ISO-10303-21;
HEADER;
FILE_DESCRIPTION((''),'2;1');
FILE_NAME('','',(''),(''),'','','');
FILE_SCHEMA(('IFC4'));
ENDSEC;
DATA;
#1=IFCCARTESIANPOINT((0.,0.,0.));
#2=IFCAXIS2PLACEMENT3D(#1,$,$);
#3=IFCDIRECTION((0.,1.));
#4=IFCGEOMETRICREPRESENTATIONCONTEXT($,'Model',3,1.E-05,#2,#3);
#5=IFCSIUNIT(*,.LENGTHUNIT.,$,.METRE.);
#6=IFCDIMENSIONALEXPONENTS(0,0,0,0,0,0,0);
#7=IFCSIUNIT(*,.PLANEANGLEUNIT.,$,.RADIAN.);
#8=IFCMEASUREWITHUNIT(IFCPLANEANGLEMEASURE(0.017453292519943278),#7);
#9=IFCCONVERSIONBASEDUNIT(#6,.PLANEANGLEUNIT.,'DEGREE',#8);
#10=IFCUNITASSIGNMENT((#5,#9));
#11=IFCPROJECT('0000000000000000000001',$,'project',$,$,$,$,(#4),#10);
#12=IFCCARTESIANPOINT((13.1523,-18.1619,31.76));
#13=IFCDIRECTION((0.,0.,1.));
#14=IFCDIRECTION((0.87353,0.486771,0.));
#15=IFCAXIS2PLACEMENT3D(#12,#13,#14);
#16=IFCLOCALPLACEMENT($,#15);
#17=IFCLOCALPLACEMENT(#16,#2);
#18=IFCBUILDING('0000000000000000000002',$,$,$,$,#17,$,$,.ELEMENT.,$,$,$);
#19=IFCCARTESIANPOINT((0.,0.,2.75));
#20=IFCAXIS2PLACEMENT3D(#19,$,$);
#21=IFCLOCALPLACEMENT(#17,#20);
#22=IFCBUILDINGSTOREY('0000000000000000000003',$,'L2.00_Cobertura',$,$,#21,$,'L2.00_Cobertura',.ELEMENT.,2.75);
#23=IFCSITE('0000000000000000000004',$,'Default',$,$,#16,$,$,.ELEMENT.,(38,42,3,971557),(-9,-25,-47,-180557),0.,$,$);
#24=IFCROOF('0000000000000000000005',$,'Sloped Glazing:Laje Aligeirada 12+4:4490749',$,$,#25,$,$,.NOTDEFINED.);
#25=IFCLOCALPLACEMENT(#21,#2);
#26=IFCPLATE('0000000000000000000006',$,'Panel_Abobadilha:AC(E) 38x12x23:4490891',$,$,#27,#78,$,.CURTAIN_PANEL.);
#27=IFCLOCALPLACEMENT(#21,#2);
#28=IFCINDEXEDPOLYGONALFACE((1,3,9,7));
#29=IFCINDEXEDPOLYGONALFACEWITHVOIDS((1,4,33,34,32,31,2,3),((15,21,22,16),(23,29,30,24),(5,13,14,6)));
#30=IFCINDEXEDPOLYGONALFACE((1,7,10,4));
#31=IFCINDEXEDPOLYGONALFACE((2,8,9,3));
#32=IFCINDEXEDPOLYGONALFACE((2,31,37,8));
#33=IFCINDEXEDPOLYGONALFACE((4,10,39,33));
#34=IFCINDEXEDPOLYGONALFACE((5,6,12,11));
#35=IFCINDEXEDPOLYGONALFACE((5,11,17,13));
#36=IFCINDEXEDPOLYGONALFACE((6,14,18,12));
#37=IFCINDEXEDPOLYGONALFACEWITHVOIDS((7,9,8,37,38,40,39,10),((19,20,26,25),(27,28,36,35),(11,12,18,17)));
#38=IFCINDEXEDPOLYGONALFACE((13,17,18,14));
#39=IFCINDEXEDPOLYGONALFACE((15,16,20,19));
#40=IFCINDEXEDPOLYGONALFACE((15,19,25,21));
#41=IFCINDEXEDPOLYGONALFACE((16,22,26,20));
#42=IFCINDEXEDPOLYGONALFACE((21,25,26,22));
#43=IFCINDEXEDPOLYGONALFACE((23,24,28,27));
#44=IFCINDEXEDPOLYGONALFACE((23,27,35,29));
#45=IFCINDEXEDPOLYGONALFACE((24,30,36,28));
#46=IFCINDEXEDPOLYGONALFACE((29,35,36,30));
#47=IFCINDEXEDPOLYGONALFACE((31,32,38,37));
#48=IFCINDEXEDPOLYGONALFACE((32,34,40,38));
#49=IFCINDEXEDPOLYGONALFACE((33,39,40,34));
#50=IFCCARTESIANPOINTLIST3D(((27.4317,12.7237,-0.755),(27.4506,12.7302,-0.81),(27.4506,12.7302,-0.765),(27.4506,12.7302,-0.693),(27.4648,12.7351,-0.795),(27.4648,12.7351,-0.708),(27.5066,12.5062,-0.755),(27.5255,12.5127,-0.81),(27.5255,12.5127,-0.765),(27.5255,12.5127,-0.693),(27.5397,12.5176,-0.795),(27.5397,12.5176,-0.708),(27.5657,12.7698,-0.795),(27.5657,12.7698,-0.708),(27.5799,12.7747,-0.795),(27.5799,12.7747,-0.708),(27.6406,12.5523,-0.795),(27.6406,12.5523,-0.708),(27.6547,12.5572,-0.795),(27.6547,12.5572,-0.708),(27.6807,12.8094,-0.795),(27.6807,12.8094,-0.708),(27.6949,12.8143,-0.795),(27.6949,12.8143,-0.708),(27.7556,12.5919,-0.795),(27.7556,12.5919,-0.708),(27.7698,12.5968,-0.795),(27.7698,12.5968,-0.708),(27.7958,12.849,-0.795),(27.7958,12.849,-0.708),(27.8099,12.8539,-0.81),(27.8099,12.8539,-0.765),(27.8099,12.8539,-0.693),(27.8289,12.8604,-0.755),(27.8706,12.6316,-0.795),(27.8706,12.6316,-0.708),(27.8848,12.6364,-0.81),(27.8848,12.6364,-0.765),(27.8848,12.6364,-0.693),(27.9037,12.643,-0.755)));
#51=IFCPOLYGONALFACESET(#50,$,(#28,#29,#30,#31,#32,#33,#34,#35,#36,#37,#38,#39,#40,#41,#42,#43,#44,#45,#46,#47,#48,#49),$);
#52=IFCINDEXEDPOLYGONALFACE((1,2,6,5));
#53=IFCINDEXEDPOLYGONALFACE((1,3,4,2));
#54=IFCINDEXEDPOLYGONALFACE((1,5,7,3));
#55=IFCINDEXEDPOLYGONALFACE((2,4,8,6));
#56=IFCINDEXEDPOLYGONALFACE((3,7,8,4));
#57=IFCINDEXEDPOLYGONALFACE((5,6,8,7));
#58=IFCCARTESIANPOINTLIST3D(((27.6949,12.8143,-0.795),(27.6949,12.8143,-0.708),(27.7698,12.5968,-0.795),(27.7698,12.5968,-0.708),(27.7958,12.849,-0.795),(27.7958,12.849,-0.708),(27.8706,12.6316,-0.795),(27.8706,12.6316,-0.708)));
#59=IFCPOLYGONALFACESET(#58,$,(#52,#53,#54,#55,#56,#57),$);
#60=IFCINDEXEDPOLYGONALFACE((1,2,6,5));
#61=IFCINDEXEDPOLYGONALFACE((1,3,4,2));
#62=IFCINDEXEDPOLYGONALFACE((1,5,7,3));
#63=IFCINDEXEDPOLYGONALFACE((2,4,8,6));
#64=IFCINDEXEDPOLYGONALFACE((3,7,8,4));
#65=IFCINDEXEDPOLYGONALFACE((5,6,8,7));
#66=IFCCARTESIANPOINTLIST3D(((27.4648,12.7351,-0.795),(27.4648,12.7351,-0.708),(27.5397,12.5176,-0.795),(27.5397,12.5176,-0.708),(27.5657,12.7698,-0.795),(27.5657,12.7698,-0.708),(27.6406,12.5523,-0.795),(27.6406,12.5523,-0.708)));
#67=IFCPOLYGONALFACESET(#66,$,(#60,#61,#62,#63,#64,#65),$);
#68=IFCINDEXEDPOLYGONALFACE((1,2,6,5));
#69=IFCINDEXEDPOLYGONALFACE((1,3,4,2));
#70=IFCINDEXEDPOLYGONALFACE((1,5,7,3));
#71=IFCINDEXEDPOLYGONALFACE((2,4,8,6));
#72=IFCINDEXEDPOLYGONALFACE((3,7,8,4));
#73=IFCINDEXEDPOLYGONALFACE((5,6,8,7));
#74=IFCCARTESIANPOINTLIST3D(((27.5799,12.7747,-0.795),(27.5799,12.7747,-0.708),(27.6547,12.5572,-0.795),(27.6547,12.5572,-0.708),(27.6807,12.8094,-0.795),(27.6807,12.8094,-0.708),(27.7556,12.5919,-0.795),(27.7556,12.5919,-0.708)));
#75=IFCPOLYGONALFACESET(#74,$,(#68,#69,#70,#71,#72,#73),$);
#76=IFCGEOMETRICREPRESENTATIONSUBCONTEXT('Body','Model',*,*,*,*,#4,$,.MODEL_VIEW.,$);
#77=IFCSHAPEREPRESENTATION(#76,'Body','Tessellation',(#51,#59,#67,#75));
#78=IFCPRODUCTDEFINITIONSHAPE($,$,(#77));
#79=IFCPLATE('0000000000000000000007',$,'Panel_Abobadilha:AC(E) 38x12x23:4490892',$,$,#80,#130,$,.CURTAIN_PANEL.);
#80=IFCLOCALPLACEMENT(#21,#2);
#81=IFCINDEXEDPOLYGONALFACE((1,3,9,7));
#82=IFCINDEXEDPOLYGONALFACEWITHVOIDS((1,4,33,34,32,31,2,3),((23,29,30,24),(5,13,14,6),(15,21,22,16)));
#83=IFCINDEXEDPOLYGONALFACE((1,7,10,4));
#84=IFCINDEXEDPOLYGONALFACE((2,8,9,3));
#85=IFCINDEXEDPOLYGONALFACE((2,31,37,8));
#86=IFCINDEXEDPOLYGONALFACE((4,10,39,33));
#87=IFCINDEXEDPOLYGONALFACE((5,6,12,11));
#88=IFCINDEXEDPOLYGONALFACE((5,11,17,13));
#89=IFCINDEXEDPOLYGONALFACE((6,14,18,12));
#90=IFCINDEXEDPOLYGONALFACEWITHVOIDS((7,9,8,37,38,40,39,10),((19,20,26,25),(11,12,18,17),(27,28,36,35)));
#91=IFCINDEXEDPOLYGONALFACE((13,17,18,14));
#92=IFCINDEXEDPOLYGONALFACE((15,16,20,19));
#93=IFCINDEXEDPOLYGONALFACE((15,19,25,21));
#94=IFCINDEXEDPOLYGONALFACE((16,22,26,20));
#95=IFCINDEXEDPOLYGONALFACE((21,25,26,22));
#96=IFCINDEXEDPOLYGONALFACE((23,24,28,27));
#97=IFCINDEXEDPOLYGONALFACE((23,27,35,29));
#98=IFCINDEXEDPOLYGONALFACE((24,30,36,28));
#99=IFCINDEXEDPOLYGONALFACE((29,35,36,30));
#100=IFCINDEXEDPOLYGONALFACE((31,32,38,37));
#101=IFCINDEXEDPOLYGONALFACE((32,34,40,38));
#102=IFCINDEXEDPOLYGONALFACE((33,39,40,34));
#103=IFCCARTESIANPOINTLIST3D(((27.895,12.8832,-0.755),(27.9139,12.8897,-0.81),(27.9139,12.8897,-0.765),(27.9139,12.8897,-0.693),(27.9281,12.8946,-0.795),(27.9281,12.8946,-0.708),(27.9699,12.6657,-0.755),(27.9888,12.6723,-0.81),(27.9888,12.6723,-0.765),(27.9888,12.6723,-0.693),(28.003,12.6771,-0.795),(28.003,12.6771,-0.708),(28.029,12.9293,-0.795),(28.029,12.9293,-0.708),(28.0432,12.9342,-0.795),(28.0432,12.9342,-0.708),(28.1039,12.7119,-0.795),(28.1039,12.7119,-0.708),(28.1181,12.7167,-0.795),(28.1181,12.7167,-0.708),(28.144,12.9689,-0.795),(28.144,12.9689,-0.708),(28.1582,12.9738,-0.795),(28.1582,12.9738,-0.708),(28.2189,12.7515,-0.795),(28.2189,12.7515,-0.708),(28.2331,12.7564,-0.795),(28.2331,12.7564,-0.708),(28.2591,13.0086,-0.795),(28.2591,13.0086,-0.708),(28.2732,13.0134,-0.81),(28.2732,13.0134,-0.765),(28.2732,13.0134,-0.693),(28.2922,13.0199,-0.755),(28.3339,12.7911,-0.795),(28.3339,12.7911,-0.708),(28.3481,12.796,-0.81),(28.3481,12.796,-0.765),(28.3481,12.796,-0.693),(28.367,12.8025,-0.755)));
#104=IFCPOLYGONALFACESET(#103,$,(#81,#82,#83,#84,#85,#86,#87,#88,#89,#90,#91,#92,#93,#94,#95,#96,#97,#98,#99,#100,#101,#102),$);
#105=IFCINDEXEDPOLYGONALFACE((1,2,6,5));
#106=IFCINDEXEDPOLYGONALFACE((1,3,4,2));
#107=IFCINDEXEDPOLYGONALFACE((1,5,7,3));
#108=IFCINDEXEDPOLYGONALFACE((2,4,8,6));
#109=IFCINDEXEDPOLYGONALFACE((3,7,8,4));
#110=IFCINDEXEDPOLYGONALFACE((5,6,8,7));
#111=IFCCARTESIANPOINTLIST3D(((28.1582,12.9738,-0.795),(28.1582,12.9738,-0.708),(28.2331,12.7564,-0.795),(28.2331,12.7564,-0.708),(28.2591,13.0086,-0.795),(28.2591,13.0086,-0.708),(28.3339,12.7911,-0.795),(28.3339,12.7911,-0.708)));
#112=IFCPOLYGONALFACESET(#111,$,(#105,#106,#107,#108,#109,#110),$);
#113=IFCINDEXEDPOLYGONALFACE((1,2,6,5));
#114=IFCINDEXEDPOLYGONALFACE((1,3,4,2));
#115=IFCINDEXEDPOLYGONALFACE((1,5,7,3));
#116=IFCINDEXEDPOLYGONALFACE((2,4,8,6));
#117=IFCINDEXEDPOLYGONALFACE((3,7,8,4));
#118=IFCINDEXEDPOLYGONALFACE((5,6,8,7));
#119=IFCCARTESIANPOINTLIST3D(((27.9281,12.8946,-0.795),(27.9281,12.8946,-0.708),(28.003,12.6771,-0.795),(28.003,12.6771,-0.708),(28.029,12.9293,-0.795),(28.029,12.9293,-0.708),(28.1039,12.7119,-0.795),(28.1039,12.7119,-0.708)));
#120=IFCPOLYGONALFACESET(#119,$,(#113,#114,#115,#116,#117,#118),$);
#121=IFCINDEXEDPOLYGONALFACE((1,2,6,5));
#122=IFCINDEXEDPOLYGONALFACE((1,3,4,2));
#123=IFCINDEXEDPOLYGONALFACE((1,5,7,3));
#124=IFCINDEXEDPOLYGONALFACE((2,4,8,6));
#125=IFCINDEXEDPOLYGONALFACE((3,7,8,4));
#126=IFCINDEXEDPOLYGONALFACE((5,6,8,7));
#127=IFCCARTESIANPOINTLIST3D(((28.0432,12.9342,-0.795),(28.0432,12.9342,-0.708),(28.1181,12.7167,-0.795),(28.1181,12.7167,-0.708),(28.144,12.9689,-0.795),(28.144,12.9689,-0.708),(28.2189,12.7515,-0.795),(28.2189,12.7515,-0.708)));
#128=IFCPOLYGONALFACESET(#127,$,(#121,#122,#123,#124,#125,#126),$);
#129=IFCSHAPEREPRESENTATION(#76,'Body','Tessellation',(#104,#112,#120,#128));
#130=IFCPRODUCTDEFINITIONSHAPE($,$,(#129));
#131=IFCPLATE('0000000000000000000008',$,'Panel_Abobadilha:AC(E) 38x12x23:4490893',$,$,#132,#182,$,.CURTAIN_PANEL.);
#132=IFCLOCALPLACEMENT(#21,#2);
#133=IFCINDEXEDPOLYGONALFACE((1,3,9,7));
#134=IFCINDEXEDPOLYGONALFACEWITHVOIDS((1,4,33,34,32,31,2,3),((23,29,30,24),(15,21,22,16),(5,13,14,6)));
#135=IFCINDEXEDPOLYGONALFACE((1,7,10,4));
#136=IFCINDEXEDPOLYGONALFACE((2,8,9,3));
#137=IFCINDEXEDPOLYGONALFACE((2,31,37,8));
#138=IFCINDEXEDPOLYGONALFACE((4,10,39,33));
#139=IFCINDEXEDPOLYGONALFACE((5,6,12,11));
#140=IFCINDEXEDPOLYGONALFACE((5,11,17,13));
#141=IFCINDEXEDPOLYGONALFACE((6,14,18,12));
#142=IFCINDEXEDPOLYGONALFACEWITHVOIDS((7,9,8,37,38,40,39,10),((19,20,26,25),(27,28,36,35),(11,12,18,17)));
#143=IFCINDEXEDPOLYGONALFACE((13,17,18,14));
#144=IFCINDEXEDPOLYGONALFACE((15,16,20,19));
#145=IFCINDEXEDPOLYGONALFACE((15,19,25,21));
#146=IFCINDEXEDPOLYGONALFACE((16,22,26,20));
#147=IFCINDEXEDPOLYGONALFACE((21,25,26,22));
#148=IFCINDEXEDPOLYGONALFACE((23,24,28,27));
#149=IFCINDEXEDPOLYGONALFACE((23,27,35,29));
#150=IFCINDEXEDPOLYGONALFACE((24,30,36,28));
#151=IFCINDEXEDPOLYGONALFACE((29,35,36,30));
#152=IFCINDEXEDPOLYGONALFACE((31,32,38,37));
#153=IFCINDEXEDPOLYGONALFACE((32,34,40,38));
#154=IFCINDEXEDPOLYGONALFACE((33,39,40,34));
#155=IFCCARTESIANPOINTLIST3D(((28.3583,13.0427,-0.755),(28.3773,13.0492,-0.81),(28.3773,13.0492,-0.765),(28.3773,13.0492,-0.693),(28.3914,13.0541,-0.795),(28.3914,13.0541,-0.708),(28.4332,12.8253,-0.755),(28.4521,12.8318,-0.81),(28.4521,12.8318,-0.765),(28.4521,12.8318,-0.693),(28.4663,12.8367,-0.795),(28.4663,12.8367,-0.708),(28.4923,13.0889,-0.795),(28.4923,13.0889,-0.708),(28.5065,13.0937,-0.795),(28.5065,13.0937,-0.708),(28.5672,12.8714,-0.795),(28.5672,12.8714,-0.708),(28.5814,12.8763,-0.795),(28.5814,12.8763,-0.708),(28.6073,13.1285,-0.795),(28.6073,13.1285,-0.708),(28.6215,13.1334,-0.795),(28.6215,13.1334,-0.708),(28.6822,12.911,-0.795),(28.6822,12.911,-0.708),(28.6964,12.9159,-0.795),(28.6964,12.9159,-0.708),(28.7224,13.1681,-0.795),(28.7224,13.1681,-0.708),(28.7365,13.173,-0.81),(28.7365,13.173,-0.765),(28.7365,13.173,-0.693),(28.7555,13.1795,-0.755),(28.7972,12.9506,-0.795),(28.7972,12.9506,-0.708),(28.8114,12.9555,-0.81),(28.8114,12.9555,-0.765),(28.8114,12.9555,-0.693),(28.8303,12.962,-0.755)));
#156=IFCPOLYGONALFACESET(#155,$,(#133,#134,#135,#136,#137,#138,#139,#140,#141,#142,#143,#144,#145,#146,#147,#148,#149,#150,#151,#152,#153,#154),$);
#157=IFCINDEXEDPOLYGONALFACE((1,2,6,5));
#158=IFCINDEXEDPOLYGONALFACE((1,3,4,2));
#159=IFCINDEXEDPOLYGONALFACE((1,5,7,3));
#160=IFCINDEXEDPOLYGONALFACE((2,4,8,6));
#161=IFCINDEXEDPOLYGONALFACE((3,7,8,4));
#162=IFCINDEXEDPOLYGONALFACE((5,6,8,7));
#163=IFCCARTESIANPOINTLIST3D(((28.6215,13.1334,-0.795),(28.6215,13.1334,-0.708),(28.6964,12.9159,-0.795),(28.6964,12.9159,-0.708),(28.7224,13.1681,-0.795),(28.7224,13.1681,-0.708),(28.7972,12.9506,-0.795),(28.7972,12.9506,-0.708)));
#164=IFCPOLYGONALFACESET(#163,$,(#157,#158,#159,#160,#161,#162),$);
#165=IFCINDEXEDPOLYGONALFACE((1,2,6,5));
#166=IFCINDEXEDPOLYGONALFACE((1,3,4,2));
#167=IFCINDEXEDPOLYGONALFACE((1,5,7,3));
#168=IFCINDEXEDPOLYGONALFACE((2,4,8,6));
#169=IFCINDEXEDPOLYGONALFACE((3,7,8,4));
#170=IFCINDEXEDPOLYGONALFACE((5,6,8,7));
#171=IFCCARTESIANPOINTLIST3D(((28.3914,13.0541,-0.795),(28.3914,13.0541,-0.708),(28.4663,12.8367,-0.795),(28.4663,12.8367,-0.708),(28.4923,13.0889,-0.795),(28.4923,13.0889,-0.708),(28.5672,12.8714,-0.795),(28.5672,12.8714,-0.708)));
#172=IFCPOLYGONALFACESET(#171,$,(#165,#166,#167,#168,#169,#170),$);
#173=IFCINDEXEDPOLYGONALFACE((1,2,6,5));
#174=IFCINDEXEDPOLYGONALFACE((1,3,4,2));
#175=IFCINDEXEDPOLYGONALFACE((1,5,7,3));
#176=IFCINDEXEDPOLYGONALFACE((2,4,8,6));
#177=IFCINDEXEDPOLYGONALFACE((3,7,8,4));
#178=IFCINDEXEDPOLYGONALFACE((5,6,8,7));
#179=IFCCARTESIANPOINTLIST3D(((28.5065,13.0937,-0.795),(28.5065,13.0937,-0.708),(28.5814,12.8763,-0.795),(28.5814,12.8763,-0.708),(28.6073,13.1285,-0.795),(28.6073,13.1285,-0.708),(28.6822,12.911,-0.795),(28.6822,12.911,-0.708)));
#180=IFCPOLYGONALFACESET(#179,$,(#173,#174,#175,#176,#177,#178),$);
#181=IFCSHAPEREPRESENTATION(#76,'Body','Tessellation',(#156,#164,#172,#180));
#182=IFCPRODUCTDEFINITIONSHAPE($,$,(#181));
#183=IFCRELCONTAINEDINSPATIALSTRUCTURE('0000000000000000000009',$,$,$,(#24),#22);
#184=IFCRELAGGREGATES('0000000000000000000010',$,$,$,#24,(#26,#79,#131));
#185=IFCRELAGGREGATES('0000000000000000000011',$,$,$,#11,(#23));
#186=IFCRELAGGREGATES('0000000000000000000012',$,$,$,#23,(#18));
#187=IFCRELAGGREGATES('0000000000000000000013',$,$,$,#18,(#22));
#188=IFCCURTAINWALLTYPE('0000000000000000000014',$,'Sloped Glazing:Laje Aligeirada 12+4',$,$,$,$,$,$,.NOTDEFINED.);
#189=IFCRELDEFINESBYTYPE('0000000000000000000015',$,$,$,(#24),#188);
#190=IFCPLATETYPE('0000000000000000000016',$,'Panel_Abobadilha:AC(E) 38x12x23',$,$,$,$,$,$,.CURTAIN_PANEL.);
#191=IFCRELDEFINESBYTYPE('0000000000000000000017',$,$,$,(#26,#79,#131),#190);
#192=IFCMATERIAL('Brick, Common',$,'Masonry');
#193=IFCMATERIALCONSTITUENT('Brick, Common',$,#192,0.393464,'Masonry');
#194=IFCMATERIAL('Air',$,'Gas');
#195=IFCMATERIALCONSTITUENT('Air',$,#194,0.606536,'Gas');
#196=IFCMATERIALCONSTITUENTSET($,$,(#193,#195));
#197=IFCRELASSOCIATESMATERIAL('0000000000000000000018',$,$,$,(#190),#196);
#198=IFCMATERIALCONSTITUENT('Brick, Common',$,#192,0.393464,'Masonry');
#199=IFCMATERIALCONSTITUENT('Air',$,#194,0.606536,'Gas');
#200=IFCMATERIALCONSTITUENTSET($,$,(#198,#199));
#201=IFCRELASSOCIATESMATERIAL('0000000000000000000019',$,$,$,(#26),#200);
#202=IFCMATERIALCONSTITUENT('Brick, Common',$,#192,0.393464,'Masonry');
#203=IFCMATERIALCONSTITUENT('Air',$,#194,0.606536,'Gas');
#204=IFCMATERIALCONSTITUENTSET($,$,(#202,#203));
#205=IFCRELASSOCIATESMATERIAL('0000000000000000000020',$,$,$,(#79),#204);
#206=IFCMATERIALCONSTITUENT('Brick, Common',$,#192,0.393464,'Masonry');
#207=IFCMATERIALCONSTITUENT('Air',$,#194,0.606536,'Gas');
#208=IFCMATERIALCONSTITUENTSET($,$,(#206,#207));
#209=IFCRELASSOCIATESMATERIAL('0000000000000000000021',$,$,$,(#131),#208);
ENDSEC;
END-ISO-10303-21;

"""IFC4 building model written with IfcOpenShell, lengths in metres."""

from ifc_helpers import new_model, entity, si_unit, converted_unit, direction, frame, origin, place, context, subcontext, project, spatial, indexed_curve, outline, extrude, source, transform, mapped, material, constituent, constituent_set, type_object, type_shapes, element, aggregate, save


model = new_model("IFC4")

# Units and contexts
model_context = context("Model", 3, precision=1e-05, world=origin(), true_north=direction((0.0, 1.0)))
body_context = subcontext(model_context, "Body", "Model", "MODEL_VIEW")
ifc_project = project(units=[si_unit("LENGTHUNIT", "METRE"), converted_unit("PLANEANGLEUNIT", "DEGREE", entity("IfcPlaneAngleMeasure", 0.017453292519943278), si_unit("PLANEANGLEUNIT", "RADIAN"), dimensions=[0, 0, 0, 0, 0, 0, 0])], contexts=[model_context])

# Site, building, storey
site_placement = place(None, frame((13.1523, -18.1619, 31.76), z_axis=(0.0, 0.0, 1.0), x_axis=(0.87353, 0.486771, 0.0)))
site = spatial("IfcSite", under=ifc_project, at=site_placement, Name="Default", CompositionType="ELEMENT", RefLatitude=(38, 42, 3, 971557), RefLongitude=(-9, -25, -47, -180557), RefElevation=0.0)
building_placement = place(site_placement, origin())
building = spatial("IfcBuilding", under=site, at=building_placement, CompositionType="ELEMENT")
storey_placement = place(building_placement, frame((0.0, 0.0, 2.75)))
storey = spatial("IfcBuildingStorey", under=building, at=storey_placement, Name="L2.00_Cobertura", LongName="L2.00_Cobertura", CompositionType="ELEMENT", Elevation=2.75)

# Roof, plates
curtain_wall_type = type_object("IfcCurtainWallType", Name="Sloped Glazing:Laje Aligeirada 12+4", PredefinedType="NOTDEFINED")
roof_placement = place(storey_placement, frame((0.0, 0.0, -2.75)))
roof = element("IfcRoof", 1, at=roof_placement, inside=storey, type_object=curtain_wall_type, Name="Sloped Glazing:Laje Aligeirada 12+4:4490749", PredefinedType="NOTDEFINED")
ifc_material_1 = material(Name="Brick, Common", Category="Masonry")
ifc_material_2 = material(Name="Air", Category="Gas")
ifc_constituent_1 = constituent(ifc_material_1, Name="Brick, Common", Category="Masonry", fraction=0.393464)
ifc_constituent_2 = constituent(ifc_material_2, Name="Air", Category="Gas", fraction=0.606536)
ifc_constituent_set_1 = constituent_set(constituents=[ifc_constituent_1, ifc_constituent_2])
plate_type_1 = type_object("IfcPlateType", Name="Panel_Abobadilha:AC(E) 38x12x23", PredefinedType="CURTAIN_PANEL", material=ifc_constituent_set_1)
shared_shape_1 = source(origin(), body_context, "Body", "SweptSolid", [
    extrude(outline(indexed_curve([(-0.19, -0.0543), (0.19, -0.0543), (0.19, -0.0093), (0.21, 0.0007), (0.19, 0.0628), (-0.19, 0.0628), (-0.21, 0.0007), (-0.19, -0.0093), (-0.19, -0.0543)], self_intersect=False), holes=[indexed_curve([(-0.0683, 0.0477), (-0.0683, -0.0393), (-0.175, -0.0393), (-0.175, 0.0477), (-0.0683, 0.0477)], self_intersect=False), indexed_curve([(0.0533, 0.0477), (0.0533, -0.0393), (-0.0533, -0.0393), (-0.0533, 0.0477), (0.0533, 0.0477)], self_intersect=False), indexed_curve([(0.175, 0.0477), (0.175, -0.0393), (0.0683, -0.0393), (0.0683, 0.0477), (0.175, 0.0477)], self_intersect=False)]), frame((0.0, 0.0543, 0.0)), (0.0, 0.0, 1.0), 0.23),
    extrude(outline(indexed_curve([(-0.0533, -0.0435), (0.0533, -0.0435), (0.0533, 0.0435), (-0.0533, 0.0435), (-0.0533, -0.0435)], self_intersect=False)), frame((0.1217, 0.0585, 0.0), z_axis=(0.0, 0.0, 1.0), x_axis=(-1.0, 0.0, 0.0)), (0.0, 0.0, 1.0), 0.23),
    extrude(outline(indexed_curve([(-0.0533, -0.0435), (0.0533, -0.0435), (0.0533, 0.0435), (-0.0533, 0.0435), (-0.0533, -0.0435)], self_intersect=False)), frame((-0.1217, 0.0585, 0.0), z_axis=(0.0, 0.0, 1.0), x_axis=(-1.0, 0.0, 0.0)), (0.0, 0.0, 1.0), 0.23),
    extrude(outline(indexed_curve([(-0.0533, -0.0435), (0.0533, -0.0435), (0.0533, 0.0435), (-0.0533, 0.0435), (-0.0533, -0.0435)], self_intersect=False)), frame((0.0, 0.0585, 0.0), z_axis=(0.0, 0.0, 1.0), x_axis=(-1.0, 0.0, 0.0)), (0.0, 0.0, 1.0), 0.23),
])
type_shapes(plate_type_1, [shared_shape_1])
ifc_constituent_3 = constituent(ifc_material_1, Name="Brick, Common", Category="Masonry", fraction=0.393464)
ifc_constituent_4 = constituent(ifc_material_2, Name="Air", Category="Gas", fraction=0.606536)
ifc_constituent_set_2 = constituent_set(constituents=[ifc_constituent_3, ifc_constituent_4])
plate_1_placement = place(roof_placement, frame((27.6303, 12.7921, 1.94), z_axis=(0.325568, -0.945519, 0.0), x_axis=(0.945519, 0.325568, 0.0)))
plate_1 = element("IfcPlate", 2, at=plate_1_placement, type_object=plate_type_1, material=ifc_constituent_set_2, Name="Panel_Abobadilha:AC(E) 38x12x23:4490891", PredefinedType="CURTAIN_PANEL", context=body_context, shape_type="MappedRepresentation", body=[
    mapped(shared_shape_1, transform((0.0, 0.0, 0.0), scale=1.0)),
])
ifc_constituent_5 = constituent(ifc_material_1, Name="Brick, Common", Category="Masonry", fraction=0.393464)
ifc_constituent_6 = constituent(ifc_material_2, Name="Air", Category="Gas", fraction=0.606536)
ifc_constituent_set_3 = constituent_set(constituents=[ifc_constituent_5, ifc_constituent_6])
plate_2_placement = place(roof_placement, frame((28.0936, 12.9516, 1.94), z_axis=(0.325568, -0.945519, 0.0), x_axis=(0.945519, 0.325568, 0.0)))
plate_2 = element("IfcPlate", 3, at=plate_2_placement, type_object=plate_type_1, material=ifc_constituent_set_3, Name="Panel_Abobadilha:AC(E) 38x12x23:4490892", PredefinedType="CURTAIN_PANEL", context=body_context, shape_type="MappedRepresentation", body=[
    mapped(shared_shape_1, transform((0.0, 0.0, 0.0), scale=1.0)),
])
ifc_constituent_7 = constituent(ifc_material_1, Name="Brick, Common", Category="Masonry", fraction=0.393464)
ifc_constituent_8 = constituent(ifc_material_2, Name="Air", Category="Gas", fraction=0.606536)
ifc_constituent_set_4 = constituent_set(constituents=[ifc_constituent_7, ifc_constituent_8])
plate_3_placement = place(roof_placement, frame((28.5569, 13.1111, 1.94), z_axis=(0.325568, -0.945519, 0.0), x_axis=(0.945519, 0.325568, 0.0)))
plate_3 = element("IfcPlate", 4, at=plate_3_placement, type_object=plate_type_1, material=ifc_constituent_set_4, Name="Panel_Abobadilha:AC(E) 38x12x23:4490893", PredefinedType="CURTAIN_PANEL", context=body_context, shape_type="MappedRepresentation", body=[
    mapped(shared_shape_1, transform((0.0, 0.0, 0.0), scale=1.0)),
])
aggregate(roof, [plate_1, plate_2, plate_3])

save(model, "model.ifc")
